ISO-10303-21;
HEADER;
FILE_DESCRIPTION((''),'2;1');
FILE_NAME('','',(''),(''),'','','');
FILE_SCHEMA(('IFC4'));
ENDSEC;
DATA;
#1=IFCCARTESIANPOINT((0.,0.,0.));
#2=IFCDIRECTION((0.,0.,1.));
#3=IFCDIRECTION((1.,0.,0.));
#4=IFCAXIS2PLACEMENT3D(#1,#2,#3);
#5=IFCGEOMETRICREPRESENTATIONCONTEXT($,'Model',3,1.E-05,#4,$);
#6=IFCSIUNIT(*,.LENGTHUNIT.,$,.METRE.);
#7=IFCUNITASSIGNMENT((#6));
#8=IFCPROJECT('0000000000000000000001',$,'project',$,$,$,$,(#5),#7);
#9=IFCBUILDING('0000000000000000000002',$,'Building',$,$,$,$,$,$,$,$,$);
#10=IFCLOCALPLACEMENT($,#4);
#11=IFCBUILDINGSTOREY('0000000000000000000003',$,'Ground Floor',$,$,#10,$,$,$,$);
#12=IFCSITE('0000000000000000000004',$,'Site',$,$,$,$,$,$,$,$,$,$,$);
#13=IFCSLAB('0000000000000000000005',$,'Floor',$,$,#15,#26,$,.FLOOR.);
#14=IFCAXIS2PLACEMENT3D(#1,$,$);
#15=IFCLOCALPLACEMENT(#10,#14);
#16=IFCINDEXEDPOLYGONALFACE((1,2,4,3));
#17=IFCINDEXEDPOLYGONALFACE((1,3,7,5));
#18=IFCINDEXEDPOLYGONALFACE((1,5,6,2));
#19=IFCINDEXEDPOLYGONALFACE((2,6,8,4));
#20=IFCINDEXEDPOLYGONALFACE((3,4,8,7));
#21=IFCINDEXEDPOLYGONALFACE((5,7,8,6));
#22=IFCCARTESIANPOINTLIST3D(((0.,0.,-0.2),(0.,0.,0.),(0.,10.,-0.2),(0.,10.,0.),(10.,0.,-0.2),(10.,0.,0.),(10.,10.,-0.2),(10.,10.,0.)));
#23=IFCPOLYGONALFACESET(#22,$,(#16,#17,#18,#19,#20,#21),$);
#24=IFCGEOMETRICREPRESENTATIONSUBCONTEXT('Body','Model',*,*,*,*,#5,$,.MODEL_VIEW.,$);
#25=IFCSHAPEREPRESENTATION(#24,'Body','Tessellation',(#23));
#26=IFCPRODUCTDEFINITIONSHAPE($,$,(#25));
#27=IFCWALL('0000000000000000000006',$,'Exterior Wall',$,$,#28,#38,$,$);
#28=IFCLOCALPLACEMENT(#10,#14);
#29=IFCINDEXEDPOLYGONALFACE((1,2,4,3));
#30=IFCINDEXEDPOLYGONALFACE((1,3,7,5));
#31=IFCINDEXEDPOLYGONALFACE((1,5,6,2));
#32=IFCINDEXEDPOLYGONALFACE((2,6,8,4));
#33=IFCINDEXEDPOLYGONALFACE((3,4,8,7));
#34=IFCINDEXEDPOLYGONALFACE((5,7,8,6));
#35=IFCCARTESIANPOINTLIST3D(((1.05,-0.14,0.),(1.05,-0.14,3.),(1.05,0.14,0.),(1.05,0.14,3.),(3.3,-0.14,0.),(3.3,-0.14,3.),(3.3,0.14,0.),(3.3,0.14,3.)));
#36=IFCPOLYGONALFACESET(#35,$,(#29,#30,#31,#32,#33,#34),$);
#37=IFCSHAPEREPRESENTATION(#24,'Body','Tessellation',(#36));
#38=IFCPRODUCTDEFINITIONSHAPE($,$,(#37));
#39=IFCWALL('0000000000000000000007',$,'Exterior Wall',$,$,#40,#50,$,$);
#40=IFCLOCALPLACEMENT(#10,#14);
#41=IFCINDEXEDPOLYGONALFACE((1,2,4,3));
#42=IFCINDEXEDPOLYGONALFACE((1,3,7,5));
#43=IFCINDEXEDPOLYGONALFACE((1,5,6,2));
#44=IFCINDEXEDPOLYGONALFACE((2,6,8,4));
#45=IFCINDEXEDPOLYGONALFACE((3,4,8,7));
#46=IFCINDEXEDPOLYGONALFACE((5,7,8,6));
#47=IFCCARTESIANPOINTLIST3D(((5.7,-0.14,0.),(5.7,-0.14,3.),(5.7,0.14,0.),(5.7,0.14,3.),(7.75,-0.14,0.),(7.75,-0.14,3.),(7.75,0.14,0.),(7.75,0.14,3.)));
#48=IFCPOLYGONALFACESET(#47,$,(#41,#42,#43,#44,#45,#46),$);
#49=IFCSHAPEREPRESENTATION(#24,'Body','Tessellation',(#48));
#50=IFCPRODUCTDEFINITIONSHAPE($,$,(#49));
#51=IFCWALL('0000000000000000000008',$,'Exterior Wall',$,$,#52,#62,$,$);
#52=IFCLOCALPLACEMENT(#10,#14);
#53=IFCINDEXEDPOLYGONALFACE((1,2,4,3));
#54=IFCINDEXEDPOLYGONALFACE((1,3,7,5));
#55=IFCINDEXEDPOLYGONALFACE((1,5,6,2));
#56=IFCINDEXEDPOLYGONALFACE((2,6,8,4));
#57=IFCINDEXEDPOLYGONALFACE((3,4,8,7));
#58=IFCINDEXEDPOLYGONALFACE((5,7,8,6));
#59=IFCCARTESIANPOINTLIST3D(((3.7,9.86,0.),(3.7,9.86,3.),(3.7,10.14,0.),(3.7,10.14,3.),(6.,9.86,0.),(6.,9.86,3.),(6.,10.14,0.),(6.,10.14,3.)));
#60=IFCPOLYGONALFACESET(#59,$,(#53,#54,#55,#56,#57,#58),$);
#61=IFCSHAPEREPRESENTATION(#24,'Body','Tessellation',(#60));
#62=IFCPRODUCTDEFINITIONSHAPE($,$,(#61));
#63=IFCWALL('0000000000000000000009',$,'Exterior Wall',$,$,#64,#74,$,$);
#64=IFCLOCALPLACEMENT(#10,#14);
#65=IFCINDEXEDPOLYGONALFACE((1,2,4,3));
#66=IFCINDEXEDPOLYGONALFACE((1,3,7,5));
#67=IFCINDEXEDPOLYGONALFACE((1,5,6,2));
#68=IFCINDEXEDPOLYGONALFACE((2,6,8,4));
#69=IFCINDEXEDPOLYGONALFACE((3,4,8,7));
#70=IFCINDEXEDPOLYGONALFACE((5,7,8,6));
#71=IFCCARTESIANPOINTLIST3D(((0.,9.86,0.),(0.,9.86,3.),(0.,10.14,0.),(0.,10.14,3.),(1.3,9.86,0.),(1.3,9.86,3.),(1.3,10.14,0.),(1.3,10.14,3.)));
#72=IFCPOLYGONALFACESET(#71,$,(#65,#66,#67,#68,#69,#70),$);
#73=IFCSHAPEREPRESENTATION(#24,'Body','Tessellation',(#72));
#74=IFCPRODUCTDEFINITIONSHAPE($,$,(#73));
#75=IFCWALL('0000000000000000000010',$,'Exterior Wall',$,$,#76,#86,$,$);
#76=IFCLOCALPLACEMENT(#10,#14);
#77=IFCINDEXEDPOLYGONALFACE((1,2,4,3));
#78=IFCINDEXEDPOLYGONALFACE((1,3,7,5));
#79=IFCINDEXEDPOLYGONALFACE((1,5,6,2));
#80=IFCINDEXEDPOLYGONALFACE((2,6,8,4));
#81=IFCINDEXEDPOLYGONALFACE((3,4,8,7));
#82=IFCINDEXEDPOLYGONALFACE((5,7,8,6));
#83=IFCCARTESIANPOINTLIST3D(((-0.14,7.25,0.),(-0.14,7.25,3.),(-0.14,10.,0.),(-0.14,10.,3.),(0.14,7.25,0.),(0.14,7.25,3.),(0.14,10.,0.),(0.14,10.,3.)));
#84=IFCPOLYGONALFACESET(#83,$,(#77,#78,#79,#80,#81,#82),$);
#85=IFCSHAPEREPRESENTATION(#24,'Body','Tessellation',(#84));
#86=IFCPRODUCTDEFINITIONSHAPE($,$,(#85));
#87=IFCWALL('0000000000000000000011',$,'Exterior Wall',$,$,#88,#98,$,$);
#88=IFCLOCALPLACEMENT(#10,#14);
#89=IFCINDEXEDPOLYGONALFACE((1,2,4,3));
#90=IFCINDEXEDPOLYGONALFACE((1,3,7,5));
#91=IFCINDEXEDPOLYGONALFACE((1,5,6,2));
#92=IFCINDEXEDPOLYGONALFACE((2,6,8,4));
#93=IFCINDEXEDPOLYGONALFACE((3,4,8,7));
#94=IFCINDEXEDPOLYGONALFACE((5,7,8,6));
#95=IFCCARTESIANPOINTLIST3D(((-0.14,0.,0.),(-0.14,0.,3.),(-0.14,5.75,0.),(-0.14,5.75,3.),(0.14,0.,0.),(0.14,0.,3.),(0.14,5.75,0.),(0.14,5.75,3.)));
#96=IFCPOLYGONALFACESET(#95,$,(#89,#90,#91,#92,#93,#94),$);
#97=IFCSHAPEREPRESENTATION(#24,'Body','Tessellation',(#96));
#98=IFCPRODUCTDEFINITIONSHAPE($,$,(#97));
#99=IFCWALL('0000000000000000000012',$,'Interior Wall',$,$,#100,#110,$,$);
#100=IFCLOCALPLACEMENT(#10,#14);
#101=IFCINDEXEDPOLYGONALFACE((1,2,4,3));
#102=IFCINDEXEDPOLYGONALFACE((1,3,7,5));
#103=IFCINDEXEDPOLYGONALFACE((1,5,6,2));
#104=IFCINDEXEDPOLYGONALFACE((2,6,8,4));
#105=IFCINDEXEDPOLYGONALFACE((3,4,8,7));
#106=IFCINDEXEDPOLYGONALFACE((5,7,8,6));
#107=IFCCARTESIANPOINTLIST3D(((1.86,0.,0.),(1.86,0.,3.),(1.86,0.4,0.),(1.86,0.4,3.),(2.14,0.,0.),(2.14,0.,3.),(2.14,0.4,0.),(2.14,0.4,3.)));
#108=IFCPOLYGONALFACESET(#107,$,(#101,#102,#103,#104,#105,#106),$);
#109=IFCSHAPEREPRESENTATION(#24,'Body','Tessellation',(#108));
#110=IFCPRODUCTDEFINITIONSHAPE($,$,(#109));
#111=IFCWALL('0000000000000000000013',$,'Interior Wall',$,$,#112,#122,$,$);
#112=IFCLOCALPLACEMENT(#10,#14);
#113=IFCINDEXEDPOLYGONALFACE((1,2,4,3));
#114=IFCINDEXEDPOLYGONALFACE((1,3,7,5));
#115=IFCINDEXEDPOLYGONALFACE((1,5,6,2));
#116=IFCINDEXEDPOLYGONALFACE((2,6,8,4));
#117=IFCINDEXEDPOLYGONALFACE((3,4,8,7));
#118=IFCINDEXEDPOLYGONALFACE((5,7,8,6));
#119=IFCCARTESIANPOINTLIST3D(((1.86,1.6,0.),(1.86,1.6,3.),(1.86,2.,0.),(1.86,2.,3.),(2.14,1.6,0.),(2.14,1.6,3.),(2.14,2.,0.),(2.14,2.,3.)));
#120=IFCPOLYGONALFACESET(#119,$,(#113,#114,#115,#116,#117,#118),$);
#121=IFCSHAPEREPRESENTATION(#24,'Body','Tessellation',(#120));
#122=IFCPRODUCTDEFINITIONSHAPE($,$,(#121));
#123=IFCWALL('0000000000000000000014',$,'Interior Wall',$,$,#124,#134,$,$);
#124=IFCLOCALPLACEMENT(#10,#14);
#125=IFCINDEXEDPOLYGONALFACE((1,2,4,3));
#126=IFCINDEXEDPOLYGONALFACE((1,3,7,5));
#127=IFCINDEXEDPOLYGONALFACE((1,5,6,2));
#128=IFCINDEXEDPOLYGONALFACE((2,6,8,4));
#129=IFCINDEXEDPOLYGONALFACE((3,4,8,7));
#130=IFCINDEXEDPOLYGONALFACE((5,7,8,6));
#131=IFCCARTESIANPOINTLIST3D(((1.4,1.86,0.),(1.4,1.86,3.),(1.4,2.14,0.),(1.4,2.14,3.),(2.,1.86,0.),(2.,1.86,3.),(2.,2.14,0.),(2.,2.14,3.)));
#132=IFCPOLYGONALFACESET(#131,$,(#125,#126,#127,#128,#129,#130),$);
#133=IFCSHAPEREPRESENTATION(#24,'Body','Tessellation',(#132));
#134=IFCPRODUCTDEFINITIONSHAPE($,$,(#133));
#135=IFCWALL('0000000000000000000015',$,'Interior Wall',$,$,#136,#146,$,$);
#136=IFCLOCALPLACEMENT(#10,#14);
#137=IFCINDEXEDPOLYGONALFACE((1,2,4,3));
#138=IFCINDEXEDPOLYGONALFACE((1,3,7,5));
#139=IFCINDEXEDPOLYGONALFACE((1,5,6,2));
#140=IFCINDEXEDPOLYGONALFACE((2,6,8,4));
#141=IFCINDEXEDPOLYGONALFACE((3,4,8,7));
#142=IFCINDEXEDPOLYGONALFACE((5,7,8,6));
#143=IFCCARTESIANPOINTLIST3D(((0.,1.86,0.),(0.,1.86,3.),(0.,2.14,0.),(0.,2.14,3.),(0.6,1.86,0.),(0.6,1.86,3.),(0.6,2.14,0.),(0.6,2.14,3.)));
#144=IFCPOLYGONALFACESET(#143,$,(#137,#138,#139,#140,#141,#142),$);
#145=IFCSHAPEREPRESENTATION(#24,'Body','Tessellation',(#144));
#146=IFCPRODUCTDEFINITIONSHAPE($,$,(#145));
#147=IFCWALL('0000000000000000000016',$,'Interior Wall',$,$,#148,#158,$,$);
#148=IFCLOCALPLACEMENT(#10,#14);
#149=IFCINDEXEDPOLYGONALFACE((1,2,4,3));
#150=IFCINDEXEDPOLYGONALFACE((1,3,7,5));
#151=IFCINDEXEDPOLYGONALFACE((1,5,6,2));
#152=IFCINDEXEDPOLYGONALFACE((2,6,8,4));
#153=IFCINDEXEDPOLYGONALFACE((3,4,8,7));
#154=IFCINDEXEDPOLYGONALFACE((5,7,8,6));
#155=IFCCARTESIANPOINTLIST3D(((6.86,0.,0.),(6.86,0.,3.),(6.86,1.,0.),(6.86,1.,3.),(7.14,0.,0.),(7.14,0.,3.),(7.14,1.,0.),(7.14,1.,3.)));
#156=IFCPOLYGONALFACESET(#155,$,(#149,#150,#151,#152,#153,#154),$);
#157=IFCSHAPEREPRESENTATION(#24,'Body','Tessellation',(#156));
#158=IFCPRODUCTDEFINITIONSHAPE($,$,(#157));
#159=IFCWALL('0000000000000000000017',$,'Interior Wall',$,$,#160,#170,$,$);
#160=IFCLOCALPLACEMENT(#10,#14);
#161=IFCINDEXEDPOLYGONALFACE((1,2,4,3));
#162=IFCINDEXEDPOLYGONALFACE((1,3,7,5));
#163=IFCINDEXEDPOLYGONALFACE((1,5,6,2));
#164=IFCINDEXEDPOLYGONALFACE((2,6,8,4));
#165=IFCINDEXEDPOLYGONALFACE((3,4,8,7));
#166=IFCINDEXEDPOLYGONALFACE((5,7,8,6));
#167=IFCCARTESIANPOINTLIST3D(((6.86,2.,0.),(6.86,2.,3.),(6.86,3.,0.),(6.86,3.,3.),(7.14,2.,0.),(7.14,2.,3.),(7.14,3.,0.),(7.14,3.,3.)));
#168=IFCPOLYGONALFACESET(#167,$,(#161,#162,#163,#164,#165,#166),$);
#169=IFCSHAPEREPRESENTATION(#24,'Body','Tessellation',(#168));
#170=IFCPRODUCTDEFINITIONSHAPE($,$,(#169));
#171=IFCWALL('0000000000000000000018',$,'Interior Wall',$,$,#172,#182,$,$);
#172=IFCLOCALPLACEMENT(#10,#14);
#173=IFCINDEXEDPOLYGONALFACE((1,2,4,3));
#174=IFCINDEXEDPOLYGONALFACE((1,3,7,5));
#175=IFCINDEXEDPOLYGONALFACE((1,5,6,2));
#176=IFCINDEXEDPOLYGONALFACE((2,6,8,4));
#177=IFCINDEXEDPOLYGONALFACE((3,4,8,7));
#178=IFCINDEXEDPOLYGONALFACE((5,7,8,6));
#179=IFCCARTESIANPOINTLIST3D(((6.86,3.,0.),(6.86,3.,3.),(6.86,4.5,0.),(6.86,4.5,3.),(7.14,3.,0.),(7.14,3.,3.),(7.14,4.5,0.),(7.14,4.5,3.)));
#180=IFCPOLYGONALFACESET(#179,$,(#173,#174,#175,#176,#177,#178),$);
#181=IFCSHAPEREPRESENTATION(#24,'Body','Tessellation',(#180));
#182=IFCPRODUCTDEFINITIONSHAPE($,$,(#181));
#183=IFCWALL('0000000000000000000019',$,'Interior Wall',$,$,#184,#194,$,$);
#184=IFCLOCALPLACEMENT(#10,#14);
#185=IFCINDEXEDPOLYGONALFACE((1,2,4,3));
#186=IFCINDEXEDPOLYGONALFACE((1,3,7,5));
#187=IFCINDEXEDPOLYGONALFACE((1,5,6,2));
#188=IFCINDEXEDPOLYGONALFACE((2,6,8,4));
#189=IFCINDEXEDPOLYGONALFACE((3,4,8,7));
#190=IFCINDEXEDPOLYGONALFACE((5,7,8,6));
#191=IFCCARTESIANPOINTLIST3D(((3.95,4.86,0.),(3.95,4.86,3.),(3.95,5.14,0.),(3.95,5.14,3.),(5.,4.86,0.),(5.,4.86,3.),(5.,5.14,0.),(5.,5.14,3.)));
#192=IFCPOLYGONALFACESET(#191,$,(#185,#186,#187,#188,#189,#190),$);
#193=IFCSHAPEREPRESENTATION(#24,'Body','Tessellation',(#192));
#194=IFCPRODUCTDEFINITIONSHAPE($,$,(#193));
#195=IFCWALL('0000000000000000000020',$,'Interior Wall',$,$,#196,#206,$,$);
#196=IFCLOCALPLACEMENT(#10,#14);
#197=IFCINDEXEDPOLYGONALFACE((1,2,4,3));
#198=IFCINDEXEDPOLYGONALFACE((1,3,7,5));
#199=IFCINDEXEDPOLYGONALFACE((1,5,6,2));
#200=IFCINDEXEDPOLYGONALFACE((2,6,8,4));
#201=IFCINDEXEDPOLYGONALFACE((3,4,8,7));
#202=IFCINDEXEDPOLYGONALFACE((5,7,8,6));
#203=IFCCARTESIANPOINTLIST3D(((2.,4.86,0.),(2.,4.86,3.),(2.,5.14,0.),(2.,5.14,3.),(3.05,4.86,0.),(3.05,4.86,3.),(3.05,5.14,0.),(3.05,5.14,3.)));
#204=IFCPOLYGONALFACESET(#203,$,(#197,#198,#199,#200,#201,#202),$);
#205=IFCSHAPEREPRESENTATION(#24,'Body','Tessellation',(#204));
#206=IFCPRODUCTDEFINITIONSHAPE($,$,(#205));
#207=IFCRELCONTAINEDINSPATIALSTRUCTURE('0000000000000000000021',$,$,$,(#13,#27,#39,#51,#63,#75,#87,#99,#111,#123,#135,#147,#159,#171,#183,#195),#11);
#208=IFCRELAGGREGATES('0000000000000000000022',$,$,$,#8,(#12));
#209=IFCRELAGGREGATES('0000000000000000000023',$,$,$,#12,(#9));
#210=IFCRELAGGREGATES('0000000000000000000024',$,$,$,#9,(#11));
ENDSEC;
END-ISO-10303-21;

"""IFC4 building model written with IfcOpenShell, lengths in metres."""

from ifc_helpers import new_model, si_unit, frame, origin_with_axes, place, context, subcontext, project, spatial, indexed_curve, outline, extrude, element, save


model = new_model("IFC4")

# Units and contexts
model_context = context("Model", 3, precision=1e-05, world=origin_with_axes())
body_context = subcontext(model_context, "Body", "Model", "MODEL_VIEW")
ifc_project = project(units=[si_unit("LENGTHUNIT", "METRE")], contexts=[model_context])

# Site, building, storey
site = spatial("IfcSite", under=ifc_project, Name="Site")
building = spatial("IfcBuilding", under=site, Name="Building")
storey_placement = place(None, origin_with_axes())
storey = spatial("IfcBuildingStorey", under=building, at=storey_placement, Name="Ground Floor")

# Slab
slab_placement = place(storey_placement, frame((0.0, 0.0, -0.2), z_axis=(0.0, 0.0, 1.0), x_axis=(1.0, 0.0, 0.0)))
element("IfcSlab", 1, at=slab_placement, inside=storey, Name="Floor", PredefinedType="FLOOR", context=body_context, shape_type="SweptSolid", body=[
    extrude(outline(indexed_curve([(0.0, 0.0), (10.0, 0.0), (10.0, 10.0), (0.0, 10.0)])), None, (0.0, 0.0, 1.0), 0.2),
])

# Walls
wall_1_placement = place(storey_placement, frame((1.05, 0.0, 0.0), z_axis=(0.0, 0.0, 1.0), x_axis=(1.0, 0.0, 0.0)))
element("IfcWall", 2, at=wall_1_placement, inside=storey, Name="Exterior Wall", context=body_context, shape_type="SweptSolid", body=[
    extrude(outline(indexed_curve([(0.0, 0.0), (0.0, 0.28), (2.25, 0.28), (2.25, 0.0), (0.0, 0.0)], self_intersect=False)), frame((0.0, -0.14, 0.0), z_axis=(0.0, 0.0, 1.0), x_axis=(1.0, 0.0, 0.0)), (0.0, 0.0, 1.0), 3.0),
])
wall_2_placement = place(storey_placement, frame((5.7, 0.0, 0.0), z_axis=(0.0, 0.0, 1.0), x_axis=(1.0, 0.0, 0.0)))
element("IfcWall", 3, at=wall_2_placement, inside=storey, Name="Exterior Wall", context=body_context, shape_type="SweptSolid", body=[
    extrude(outline(indexed_curve([(0.0, 0.0), (0.0, 0.28), (2.05, 0.28), (2.05, 0.0), (0.0, 0.0)], self_intersect=False)), frame((0.0, -0.14, 0.0), z_axis=(0.0, 0.0, 1.0), x_axis=(1.0, 0.0, 0.0)), (0.0, 0.0, 1.0), 3.0),
])
wall_3_placement = place(storey_placement, frame((6.0, 10.0, 0.0), z_axis=(0.0, 0.0, 1.0), x_axis=(-1.0, 0.0, 0.0)))
element("IfcWall", 4, at=wall_3_placement, inside=storey, Name="Exterior Wall", context=body_context, shape_type="SweptSolid", body=[
    extrude(outline(indexed_curve([(0.0, 0.0), (0.0, 0.28), (2.3, 0.28), (2.3, 0.0), (0.0, 0.0)], self_intersect=False)), frame((0.0, -0.14, 0.0), z_axis=(0.0, 0.0, 1.0), x_axis=(1.0, 0.0, 0.0)), (0.0, 0.0, 1.0), 3.0),
])
wall_4_placement = place(storey_placement, frame((1.3, 10.0, 0.0), z_axis=(0.0, 0.0, 1.0), x_axis=(-1.0, 0.0, 0.0)))
element("IfcWall", 5, at=wall_4_placement, inside=storey, Name="Exterior Wall", context=body_context, shape_type="SweptSolid", body=[
    extrude(outline(indexed_curve([(0.0, 0.0), (0.0, 0.28), (1.3, 0.28), (1.3, 0.0), (0.0, 0.0)], self_intersect=False)), frame((0.0, -0.14, 0.0), z_axis=(0.0, 0.0, 1.0), x_axis=(1.0, 0.0, 0.0)), (0.0, 0.0, 1.0), 3.0),
])
wall_5_placement = place(storey_placement, frame((0.0, 10.0, 0.0), z_axis=(0.0, 0.0, 1.0), x_axis=(0.0, -1.0, 0.0)))
element("IfcWall", 6, at=wall_5_placement, inside=storey, Name="Exterior Wall", context=body_context, shape_type="SweptSolid", body=[
    extrude(outline(indexed_curve([(0.0, 0.0), (0.0, 0.28), (2.75, 0.28), (2.75, 0.0), (0.0, 0.0)], self_intersect=False)), frame((0.0, -0.14, 0.0), z_axis=(0.0, 0.0, 1.0), x_axis=(1.0, 0.0, 0.0)), (0.0, 0.0, 1.0), 3.0),
])
wall_6_placement = place(storey_placement, frame((0.0, 5.75, 0.0), z_axis=(0.0, 0.0, 1.0), x_axis=(0.0, -1.0, 0.0)))
element("IfcWall", 7, at=wall_6_placement, inside=storey, Name="Exterior Wall", context=body_context, shape_type="SweptSolid", body=[
    extrude(outline(indexed_curve([(0.0, 0.0), (0.0, 0.28), (5.75, 0.28), (5.75, 0.0), (0.0, 0.0)], self_intersect=False)), frame((0.0, -0.14, 0.0), z_axis=(0.0, 0.0, 1.0), x_axis=(1.0, 0.0, 0.0)), (0.0, 0.0, 1.0), 3.0),
])
wall_7_placement = place(storey_placement, frame((2.0, 0.0, 0.0), z_axis=(0.0, 0.0, 1.0), x_axis=(0.0, 1.0, 0.0)))
element("IfcWall", 8, at=wall_7_placement, inside=storey, Name="Interior Wall", context=body_context, shape_type="SweptSolid", body=[
    extrude(outline(indexed_curve([(0.0, 0.0), (0.0, 0.28), (0.4, 0.28), (0.4, 0.0), (0.0, 0.0)], self_intersect=False)), frame((0.0, -0.14, 0.0), z_axis=(0.0, 0.0, 1.0), x_axis=(1.0, 0.0, 0.0)), (0.0, 0.0, 1.0), 3.0),
])
wall_8_placement = place(storey_placement, frame((2.0, 1.6, 0.0), z_axis=(0.0, 0.0, 1.0), x_axis=(0.0, 1.0, 0.0)))
element("IfcWall", 9, at=wall_8_placement, inside=storey, Name="Interior Wall", context=body_context, shape_type="SweptSolid", body=[
    extrude(outline(indexed_curve([(0.0, 0.0), (0.0, 0.28), (0.4, 0.28), (0.4, 0.0), (0.0, 0.0)], self_intersect=False)), frame((0.0, -0.14, 0.0), z_axis=(0.0, 0.0, 1.0), x_axis=(1.0, 0.0, 0.0)), (0.0, 0.0, 1.0), 3.0),
])
for number, where, z_axis, x_axis, name in (
    (10, (2.0, 2.0, 0.0), (0.0, 0.0, 1.0), (-1.0, 0.0, 0.0), "Interior Wall"),
    (11, (0.6, 2.0, 0.0), (0.0, 0.0, 1.0), (-1.0, 0.0, 0.0), "Interior Wall"),
):
    element("IfcWall", number, at=place(storey_placement, frame(where, z_axis=z_axis, x_axis=x_axis)), inside=storey, Name=name, context=body_context, shape_type="SweptSolid", body=[
        extrude(outline(indexed_curve([(0.0, 0.0), (0.0, 0.28), (0.6, 0.28), (0.6, 0.0), (0.0, 0.0)], self_intersect=False)), frame((0.0, -0.14, 0.0), z_axis=(0.0, 0.0, 1.0), x_axis=(1.0, 0.0, 0.0)), (0.0, 0.0, 1.0), 3.0),
    ])
for number, where, z_axis, x_axis, name in (
    (12, (7.0, 0.0, 0.0), (0.0, 0.0, 1.0), (0.0, 1.0, 0.0), "Interior Wall"),
    (13, (7.0, 2.0, 0.0), (0.0, 0.0, 1.0), (0.0, 1.0, 0.0), "Interior Wall"),
):
    element("IfcWall", number, at=place(storey_placement, frame(where, z_axis=z_axis, x_axis=x_axis)), inside=storey, Name=name, context=body_context, shape_type="SweptSolid", body=[
        extrude(outline(indexed_curve([(0.0, 0.0), (0.0, 0.28), (1.0, 0.28), (1.0, 0.0), (0.0, 0.0)], self_intersect=False)), frame((0.0, -0.14, 0.0), z_axis=(0.0, 0.0, 1.0), x_axis=(1.0, 0.0, 0.0)), (0.0, 0.0, 1.0), 3.0),
    ])
wall_9_placement = place(storey_placement, frame((7.0, 3.0, 0.0), z_axis=(0.0, 0.0, 1.0), x_axis=(0.0, 1.0, 0.0)))
element("IfcWall", 14, at=wall_9_placement, inside=storey, Name="Interior Wall", context=body_context, shape_type="SweptSolid", body=[
    extrude(outline(indexed_curve([(0.0, 0.0), (0.0, 0.28), (1.5, 0.28), (1.5, 0.0), (0.0, 0.0)], self_intersect=False)), frame((0.0, -0.14, 0.0), z_axis=(0.0, 0.0, 1.0), x_axis=(1.0, 0.0, 0.0)), (0.0, 0.0, 1.0), 3.0),
])
for number, where, z_axis, x_axis, name in (
    (15, (5.0, 5.0, 0.0), (0.0, 0.0, 1.0), (-1.0, 0.0, 0.0), "Interior Wall"),
    (16, (3.05, 5.0, 0.0), (0.0, 0.0, 1.0), (-1.0, 0.0, 0.0), "Interior Wall"),
):
    element("IfcWall", number, at=place(storey_placement, frame(where, z_axis=z_axis, x_axis=x_axis)), inside=storey, Name=name, context=body_context, shape_type="SweptSolid", body=[
        extrude(outline(indexed_curve([(0.0, 0.0), (0.0, 0.28), (1.05, 0.28), (1.05, 0.0), (0.0, 0.0)], self_intersect=False)), frame((0.0, -0.14, 0.0), z_axis=(0.0, 0.0, 1.0), x_axis=(1.0, 0.0, 0.0)), (0.0, 0.0, 1.0), 3.0),
    ])

save(model, "model.ifc")
